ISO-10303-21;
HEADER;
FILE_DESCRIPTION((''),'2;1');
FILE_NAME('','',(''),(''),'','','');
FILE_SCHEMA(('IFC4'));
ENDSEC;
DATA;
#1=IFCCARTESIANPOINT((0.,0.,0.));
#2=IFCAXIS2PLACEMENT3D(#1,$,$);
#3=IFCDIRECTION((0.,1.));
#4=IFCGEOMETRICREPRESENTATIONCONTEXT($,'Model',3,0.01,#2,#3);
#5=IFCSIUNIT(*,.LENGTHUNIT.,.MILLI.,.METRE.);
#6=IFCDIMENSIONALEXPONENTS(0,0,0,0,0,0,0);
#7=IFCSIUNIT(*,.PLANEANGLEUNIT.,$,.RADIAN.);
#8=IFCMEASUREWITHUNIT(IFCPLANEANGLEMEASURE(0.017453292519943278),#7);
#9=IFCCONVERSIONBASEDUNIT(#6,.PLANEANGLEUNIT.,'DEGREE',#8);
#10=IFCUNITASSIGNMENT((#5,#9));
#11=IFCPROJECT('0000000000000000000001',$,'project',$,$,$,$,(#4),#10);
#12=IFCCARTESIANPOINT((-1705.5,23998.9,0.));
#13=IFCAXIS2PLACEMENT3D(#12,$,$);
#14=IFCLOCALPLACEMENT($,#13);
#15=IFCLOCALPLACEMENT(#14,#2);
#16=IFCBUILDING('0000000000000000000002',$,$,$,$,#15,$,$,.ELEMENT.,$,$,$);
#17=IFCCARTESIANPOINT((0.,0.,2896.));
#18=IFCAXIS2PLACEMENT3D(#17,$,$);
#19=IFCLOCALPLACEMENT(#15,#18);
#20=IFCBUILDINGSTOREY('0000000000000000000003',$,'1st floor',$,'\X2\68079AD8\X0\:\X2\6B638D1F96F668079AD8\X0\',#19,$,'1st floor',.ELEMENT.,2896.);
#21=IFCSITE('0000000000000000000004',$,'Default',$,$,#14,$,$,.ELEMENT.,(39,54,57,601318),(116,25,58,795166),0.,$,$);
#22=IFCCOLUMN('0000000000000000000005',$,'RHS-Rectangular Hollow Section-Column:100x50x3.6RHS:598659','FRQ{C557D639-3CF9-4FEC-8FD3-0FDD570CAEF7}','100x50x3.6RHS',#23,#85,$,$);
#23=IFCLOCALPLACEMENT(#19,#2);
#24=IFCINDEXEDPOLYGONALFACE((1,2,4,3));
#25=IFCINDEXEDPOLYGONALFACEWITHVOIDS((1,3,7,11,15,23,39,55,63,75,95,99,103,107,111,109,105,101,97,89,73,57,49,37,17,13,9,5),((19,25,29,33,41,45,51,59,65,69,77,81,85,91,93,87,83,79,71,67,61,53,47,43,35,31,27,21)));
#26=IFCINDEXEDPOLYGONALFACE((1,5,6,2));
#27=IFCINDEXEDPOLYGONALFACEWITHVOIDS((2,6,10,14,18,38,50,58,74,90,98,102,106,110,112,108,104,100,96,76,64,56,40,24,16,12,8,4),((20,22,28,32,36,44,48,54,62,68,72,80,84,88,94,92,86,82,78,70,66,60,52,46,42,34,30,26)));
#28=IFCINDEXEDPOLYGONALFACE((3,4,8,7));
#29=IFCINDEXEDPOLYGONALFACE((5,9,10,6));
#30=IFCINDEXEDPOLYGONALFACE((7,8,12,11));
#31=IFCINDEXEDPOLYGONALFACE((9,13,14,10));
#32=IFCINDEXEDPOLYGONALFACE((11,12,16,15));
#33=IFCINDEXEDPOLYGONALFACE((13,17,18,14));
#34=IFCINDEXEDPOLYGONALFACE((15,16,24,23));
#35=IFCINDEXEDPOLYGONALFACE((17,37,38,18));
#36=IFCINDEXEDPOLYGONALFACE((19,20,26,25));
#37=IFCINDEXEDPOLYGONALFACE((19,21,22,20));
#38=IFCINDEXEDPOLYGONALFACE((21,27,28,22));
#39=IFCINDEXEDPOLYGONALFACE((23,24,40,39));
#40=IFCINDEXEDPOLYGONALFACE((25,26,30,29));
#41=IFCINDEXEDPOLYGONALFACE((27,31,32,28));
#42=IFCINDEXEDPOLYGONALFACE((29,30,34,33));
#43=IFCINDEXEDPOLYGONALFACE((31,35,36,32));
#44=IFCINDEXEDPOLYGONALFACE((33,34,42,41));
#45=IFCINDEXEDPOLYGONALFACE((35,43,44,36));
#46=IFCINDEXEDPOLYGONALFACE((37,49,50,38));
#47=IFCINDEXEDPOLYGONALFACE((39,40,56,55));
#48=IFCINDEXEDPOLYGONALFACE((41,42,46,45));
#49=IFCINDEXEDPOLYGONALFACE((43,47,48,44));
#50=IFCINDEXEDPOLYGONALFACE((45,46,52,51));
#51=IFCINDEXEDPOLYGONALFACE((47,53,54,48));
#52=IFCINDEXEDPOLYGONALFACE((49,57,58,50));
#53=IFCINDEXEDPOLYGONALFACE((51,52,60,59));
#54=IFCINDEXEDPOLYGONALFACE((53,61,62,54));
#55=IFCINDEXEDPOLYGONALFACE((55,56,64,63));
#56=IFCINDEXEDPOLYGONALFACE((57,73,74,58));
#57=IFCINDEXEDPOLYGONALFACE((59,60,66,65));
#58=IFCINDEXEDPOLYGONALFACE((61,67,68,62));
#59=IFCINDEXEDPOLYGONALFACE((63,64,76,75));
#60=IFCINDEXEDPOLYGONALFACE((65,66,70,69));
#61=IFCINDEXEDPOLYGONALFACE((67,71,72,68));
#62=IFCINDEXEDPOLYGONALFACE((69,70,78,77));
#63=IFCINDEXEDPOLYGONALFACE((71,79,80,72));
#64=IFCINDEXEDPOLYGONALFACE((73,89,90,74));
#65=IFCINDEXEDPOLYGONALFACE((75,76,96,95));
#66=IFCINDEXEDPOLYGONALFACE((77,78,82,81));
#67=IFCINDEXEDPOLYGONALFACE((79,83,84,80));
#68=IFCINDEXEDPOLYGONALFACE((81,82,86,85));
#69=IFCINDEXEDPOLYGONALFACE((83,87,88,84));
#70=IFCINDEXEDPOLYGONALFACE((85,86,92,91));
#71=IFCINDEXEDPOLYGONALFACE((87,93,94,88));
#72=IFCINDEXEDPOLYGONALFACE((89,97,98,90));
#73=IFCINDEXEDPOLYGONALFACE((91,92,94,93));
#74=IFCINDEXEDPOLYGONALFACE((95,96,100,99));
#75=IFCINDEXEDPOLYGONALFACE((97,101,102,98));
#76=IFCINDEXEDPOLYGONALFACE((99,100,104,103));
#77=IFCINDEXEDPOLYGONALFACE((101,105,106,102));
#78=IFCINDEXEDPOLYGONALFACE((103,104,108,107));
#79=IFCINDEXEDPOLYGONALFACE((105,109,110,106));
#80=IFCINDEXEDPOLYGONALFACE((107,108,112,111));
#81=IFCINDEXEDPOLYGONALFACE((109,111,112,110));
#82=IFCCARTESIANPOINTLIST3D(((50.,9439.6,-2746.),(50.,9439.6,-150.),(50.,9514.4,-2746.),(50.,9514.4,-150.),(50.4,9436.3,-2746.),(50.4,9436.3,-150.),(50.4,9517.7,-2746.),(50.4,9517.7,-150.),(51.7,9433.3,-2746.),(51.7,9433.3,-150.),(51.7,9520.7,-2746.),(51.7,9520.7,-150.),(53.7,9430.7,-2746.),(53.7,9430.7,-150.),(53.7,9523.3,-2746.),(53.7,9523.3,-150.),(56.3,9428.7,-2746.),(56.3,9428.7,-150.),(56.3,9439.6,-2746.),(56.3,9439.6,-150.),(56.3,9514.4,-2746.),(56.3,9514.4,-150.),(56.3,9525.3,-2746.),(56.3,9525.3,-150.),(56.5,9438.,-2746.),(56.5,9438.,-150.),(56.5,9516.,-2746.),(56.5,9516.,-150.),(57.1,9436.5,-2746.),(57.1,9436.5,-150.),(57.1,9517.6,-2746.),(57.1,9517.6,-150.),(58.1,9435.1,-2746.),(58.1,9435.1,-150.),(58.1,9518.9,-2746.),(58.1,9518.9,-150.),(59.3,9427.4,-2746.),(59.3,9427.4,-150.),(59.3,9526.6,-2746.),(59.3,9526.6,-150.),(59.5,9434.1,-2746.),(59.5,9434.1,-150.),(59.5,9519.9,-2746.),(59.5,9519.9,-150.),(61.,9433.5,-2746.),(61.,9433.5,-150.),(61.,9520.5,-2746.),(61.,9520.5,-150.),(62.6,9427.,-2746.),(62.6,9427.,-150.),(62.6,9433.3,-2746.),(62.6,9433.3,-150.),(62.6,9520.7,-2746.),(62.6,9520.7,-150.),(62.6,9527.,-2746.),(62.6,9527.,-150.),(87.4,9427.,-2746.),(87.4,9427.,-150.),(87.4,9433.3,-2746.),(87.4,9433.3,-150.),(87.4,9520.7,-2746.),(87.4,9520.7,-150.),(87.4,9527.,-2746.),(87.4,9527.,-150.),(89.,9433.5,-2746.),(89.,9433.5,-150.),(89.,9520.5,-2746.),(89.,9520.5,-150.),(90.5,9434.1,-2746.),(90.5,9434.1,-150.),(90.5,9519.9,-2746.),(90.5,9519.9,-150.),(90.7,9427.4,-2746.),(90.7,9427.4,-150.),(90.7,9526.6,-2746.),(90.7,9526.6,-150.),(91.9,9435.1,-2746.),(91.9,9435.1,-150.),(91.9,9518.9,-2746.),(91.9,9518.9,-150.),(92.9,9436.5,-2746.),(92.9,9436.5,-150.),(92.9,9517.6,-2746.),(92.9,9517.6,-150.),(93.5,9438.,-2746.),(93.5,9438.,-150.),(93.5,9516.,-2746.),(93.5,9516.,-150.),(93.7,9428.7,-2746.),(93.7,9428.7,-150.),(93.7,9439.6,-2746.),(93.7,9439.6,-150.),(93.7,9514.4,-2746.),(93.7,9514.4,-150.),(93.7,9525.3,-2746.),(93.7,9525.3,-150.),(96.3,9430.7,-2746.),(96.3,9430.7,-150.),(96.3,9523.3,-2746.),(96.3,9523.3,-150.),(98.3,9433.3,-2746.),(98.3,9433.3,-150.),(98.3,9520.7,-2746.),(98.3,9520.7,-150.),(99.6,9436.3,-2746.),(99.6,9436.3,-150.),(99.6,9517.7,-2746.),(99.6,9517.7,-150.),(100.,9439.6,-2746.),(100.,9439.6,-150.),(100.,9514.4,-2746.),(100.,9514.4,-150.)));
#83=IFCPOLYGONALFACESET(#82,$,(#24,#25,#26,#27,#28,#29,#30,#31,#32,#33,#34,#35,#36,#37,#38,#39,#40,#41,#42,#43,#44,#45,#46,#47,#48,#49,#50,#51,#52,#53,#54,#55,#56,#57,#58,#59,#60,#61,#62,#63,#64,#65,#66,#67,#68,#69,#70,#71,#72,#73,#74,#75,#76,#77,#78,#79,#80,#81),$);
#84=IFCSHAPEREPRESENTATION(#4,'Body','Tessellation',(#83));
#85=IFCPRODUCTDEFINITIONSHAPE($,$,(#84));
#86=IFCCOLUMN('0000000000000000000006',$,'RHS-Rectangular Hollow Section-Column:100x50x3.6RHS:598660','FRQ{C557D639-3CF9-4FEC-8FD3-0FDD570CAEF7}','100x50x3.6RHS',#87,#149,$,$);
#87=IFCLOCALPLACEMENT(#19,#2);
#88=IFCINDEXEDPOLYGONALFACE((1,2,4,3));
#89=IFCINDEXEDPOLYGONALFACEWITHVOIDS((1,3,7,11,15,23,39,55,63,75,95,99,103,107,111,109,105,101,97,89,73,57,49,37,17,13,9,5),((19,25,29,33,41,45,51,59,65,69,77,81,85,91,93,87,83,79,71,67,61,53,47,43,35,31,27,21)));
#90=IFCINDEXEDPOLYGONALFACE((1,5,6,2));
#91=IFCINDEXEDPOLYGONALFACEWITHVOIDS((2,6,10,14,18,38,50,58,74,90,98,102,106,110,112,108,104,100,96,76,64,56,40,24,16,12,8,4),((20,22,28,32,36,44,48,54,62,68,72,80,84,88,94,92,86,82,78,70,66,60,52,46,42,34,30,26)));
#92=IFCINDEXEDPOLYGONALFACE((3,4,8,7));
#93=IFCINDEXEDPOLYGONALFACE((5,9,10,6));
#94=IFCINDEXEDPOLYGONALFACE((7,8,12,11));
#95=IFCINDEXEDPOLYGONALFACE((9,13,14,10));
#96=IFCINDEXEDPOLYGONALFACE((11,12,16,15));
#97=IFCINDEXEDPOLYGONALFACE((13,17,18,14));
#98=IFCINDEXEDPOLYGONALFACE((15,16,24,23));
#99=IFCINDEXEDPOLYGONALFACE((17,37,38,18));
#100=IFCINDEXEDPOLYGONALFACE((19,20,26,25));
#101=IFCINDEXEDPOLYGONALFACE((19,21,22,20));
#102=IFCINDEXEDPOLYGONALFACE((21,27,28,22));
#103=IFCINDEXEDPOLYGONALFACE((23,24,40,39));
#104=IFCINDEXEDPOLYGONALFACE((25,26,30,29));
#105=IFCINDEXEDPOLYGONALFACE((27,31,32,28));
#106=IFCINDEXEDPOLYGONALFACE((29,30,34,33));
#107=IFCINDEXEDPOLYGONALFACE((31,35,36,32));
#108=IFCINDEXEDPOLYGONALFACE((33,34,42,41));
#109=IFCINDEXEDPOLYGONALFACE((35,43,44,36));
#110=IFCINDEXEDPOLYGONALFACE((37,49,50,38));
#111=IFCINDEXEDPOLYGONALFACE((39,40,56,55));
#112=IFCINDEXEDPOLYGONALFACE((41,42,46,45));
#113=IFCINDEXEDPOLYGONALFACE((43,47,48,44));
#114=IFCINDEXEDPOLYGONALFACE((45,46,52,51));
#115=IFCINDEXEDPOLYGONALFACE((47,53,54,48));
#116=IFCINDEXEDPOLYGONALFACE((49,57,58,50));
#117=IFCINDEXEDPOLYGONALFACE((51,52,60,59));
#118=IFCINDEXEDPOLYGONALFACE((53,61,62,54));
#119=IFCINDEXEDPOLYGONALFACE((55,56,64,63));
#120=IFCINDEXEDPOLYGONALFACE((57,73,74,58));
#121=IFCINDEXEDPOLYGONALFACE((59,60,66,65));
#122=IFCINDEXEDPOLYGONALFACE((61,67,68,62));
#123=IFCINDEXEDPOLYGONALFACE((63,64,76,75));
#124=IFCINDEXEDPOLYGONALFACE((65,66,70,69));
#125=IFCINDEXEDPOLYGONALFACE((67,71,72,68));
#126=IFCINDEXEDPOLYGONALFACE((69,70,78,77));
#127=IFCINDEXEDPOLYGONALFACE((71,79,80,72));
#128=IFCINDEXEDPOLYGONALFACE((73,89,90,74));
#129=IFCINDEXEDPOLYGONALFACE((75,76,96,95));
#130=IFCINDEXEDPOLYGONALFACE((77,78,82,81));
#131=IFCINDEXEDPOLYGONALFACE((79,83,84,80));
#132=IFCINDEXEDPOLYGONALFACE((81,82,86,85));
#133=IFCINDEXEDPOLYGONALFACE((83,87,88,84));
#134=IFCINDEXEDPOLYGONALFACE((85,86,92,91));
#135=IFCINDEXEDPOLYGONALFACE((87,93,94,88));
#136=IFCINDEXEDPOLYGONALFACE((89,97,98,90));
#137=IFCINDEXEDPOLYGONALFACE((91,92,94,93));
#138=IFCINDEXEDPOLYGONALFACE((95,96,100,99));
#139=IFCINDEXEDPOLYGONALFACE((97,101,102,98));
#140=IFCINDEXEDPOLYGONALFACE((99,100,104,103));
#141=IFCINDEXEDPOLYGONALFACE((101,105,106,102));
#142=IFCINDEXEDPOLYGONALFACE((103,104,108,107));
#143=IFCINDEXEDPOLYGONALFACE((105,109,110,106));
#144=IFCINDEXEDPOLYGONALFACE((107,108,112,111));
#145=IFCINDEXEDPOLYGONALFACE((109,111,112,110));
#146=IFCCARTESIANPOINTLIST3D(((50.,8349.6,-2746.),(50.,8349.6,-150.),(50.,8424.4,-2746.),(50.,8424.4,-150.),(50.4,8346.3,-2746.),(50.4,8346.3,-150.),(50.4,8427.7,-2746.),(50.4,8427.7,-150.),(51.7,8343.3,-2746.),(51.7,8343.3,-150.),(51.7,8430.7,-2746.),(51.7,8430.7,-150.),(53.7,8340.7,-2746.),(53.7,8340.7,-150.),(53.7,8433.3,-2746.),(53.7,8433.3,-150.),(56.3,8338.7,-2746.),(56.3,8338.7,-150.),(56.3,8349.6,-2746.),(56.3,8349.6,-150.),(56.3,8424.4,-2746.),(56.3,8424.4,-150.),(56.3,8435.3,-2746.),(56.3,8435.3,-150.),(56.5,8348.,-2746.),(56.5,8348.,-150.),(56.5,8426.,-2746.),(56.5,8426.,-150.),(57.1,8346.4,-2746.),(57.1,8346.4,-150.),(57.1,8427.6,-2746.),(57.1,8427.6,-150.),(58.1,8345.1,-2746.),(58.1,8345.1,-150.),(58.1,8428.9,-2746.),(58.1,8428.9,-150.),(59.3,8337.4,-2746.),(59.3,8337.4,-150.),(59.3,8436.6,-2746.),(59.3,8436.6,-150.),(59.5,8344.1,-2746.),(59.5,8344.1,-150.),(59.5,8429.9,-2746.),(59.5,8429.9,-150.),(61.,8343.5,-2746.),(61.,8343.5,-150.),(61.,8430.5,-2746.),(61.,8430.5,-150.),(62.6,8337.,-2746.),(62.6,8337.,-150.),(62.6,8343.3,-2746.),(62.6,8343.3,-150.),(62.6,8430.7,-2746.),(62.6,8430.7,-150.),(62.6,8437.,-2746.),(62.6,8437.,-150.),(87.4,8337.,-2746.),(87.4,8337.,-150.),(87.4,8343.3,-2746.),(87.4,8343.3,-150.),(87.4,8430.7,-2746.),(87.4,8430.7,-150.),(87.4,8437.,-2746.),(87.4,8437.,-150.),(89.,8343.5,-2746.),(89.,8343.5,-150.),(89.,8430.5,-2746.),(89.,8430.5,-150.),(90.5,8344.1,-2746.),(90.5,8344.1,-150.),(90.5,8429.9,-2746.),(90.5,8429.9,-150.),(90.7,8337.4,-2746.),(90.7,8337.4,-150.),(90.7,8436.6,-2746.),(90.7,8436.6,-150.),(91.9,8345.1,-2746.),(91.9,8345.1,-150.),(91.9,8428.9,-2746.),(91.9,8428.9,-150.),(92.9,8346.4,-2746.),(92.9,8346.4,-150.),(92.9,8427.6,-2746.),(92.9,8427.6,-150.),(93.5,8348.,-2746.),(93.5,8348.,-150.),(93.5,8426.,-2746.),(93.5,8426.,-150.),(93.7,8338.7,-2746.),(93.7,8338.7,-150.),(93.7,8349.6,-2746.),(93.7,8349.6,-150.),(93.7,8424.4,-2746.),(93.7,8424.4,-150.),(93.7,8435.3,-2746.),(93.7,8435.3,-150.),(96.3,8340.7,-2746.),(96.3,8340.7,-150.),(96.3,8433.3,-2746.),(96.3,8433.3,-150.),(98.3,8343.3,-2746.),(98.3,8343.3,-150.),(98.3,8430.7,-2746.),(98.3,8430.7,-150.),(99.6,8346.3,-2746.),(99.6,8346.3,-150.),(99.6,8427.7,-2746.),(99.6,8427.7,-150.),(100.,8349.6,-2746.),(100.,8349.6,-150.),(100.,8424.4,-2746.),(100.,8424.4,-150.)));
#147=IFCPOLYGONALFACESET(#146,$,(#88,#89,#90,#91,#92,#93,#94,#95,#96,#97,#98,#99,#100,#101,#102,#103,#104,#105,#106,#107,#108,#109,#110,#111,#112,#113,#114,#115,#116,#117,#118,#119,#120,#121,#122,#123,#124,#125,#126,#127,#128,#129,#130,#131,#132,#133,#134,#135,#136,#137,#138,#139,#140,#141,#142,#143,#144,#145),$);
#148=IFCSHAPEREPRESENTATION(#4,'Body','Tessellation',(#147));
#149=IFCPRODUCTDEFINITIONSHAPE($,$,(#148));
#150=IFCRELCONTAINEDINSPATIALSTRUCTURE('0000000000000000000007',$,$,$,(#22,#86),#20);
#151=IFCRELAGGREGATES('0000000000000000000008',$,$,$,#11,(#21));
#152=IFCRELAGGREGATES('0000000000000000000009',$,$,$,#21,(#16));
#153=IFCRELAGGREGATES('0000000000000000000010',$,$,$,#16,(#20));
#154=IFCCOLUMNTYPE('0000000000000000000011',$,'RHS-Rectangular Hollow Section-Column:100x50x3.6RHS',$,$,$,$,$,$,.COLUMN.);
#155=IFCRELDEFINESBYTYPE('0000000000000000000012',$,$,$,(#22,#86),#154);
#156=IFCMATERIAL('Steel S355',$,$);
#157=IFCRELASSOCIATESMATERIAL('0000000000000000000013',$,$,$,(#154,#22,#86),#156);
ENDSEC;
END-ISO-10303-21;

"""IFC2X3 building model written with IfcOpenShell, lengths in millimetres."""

from ifc_helpers import new_model, entity, si_unit, converted_unit, point, direction, frame, frame_2d, origin, origin_2d, place, context, project, spatial, circle_curve, line_curve, trimmed, segment, composite_curve, hollow_rectangle, outline, extrude, clip, halfspace, material, type_object, element, save


model = new_model("IFC2X3")

# Units and contexts
model_context = context("Model", 3, precision=0.01, world=origin(), true_north=direction((0.0, 1.0)))
ifc_project = project(units=[si_unit("LENGTHUNIT", "METRE", prefix="MILLI"), converted_unit("PLANEANGLEUNIT", "DEGREE", entity("IfcPlaneAngleMeasure", 0.017453292519943278), si_unit("PLANEANGLEUNIT", "RADIAN"), dimensions=[0, 0, 0, 0, 0, 0, 0])], contexts=[model_context])

# Site, building, storey
site_placement = place(None, frame((-1705.5, 23998.9, 0.0)))
site = spatial("IfcSite", under=ifc_project, at=site_placement, Name="Default", CompositionType="ELEMENT", RefLatitude=(39, 54, 57, 601318), RefLongitude=(116, 25, 58, 795166), RefElevation=0.0)
building_placement = place(site_placement, origin())
building = spatial("IfcBuilding", under=site, at=building_placement, CompositionType="ELEMENT")
storey_placement = place(building_placement, frame((0.0, 0.0, 2896.0)))
storey = spatial("IfcBuildingStorey", under=building, at=storey_placement, Name="1st floor", ObjectType="标高:正负零标高", LongName="1st floor", CompositionType="ELEMENT", Elevation=2896.0)

# Columns, openings
ifc_material_1 = material(Name="Steel S355")
column_type_1 = type_object("IfcColumnType", Name="RHS-Rectangular Hollow Section-Column:100x50x3.6RHS", PredefinedType="COLUMN", material=ifc_material_1)
column_1_placement = place(storey_placement, frame((75.0, 9477.0, -19.1)))
column_1 = element("IfcColumn", 1, at=column_1_placement, inside=storey, type_object=column_type_1, material=ifc_material_1, Name="RHS-Rectangular Hollow Section-Column:100x50x3.6RHS:598659", Description="FRQ{C557D639-3CF9-4FEC-8FD3-0FDD570CAEF7}", ObjectType="100x50x3.6RHS", context=model_context, shape_type="Clipping", body=[
    clip(clip(extrude(hollow_rectangle(XDim=50.0, YDim=100.0, WallThickness=6.3, InnerFilletRadius=6.3, OuterFilletRadius=12.6, at=origin_2d()), origin(), (0.0, 0.0, -1.0), 2782.8), halfspace(frame((-75.0, -9477.0, -55.9), z_axis=(0.0, 0.0, -1.0), x_axis=(-1.0, 0.0, 0.0)), True)), halfspace(frame((-75.0, -9477.0, -2726.9), z_axis=(0.0, 0.0, 1.0), x_axis=(1.0, 0.0, 0.0)), True)),
])
opening_1_placement = place(column_1_placement, frame((0.0, -150.1, -130.9), z_axis=(0.0, 1.0, 0.0), x_axis=(-1.0, 0.0, 0.0)))
element("IfcOpeningElement", 2, at=opening_1_placement, cuts=column_1, ObjectType="Opening", context=model_context, shape_type="SweptSolid", body=[
    extrude(outline(composite_curve([segment(trimmed(circle_curve(frame_2d((43.0, 32.0), x_axis=(1.0, 0.0)), 32.0), [point((43.0, 0.0))], [point((75.0, 32.0))], True, "CARTESIAN"), True, "CONTINUOUS"), segment(trimmed(line_curve((75.0, 32.0), (0.0, 1.0), 86.0), [point((75.0, 32.0))], [point((75.0, 118.0))], True, "CARTESIAN"), True, "CONTINUOUS"), segment(trimmed(circle_curve(frame_2d((43.0, 118.0), x_axis=(1.0, 0.0)), 32.0), [point((75.0, 118.0))], [point((43.0, 150.0))], True, "CARTESIAN"), True, "CONTINUOUS"), segment(trimmed(line_curve((43.0, 150.0), (-1.0, 0.0), 86.0), [point((43.0, 150.0))], [point((-43.0, 150.0))], True, "CARTESIAN"), True, "CONTINUOUS"), segment(trimmed(circle_curve(frame_2d((-43.0, 118.0), x_axis=(1.0, 0.0)), 32.0), [point((-43.0, 150.0))], [point((-75.0, 118.0))], True, "CARTESIAN"), True, "CONTINUOUS"), segment(trimmed(line_curve((-75.0, 118.0), (0.0, -1.0), 86.0), [point((-75.0, 118.0))], [point((-75.0, 32.0))], True, "CARTESIAN"), True, "CONTINUOUS"), segment(trimmed(circle_curve(frame_2d((-43.0, 32.0), x_axis=(1.0, 0.0)), 32.0), [point((-75.0, 32.0))], [point((-43.0, 0.0))], True, "CARTESIAN"), True, "CONTINUOUS"), segment(trimmed(line_curve((-43.0, 0.0), (1.0, 0.0), 86.0), [point((-43.0, 0.0))], [point((43.0, 0.0))], True, "CARTESIAN"), True, "CONTINUOUS")], self_intersect="UNKNOWN")), origin(), (0.0, 0.0, 1.0), 300.2),
])
column_2_placement = place(storey_placement, frame((75.0, 8387.0, -19.1)))
column_2 = element("IfcColumn", 3, at=column_2_placement, inside=storey, type_object=column_type_1, material=ifc_material_1, Name="RHS-Rectangular Hollow Section-Column:100x50x3.6RHS:598660", Description="FRQ{C557D639-3CF9-4FEC-8FD3-0FDD570CAEF7}", ObjectType="100x50x3.6RHS", context=model_context, shape_type="Clipping", body=[
    clip(clip(extrude(hollow_rectangle(XDim=50.0, YDim=100.0, WallThickness=6.3, InnerFilletRadius=6.3, OuterFilletRadius=12.6, at=origin_2d()), origin(), (0.0, 0.0, -1.0), 2782.8), halfspace(frame((-75.0, -8387.0, -2726.9), z_axis=(0.0, 0.0, 1.0), x_axis=(1.0, 0.0, 0.0)), True)), halfspace(frame((-75.0, -8387.0, -55.9), z_axis=(0.0, 0.0, -1.0), x_axis=(-1.0, 0.0, 0.0)), True)),
])
opening_2_placement = place(column_2_placement, frame((0.0, -150.1, -130.9), z_axis=(0.0, 1.0, 0.0), x_axis=(-1.0, 0.0, 0.0)))
element("IfcOpeningElement", 4, at=opening_2_placement, cuts=column_2, ObjectType="Opening", context=model_context, shape_type="SweptSolid", body=[
    extrude(outline(composite_curve([segment(trimmed(circle_curve(frame_2d((43.0, 32.0), x_axis=(1.0, 0.0)), 32.0), [point((43.0, 0.0))], [point((75.0, 32.0))], True, "CARTESIAN"), True, "CONTINUOUS"), segment(trimmed(line_curve((75.0, 32.0), (0.0, 1.0), 86.0), [point((75.0, 32.0))], [point((75.0, 118.0))], True, "CARTESIAN"), True, "CONTINUOUS"), segment(trimmed(circle_curve(frame_2d((43.0, 118.0), x_axis=(1.0, 0.0)), 32.0), [point((75.0, 118.0))], [point((43.0, 150.0))], True, "CARTESIAN"), True, "CONTINUOUS"), segment(trimmed(line_curve((43.0, 150.0), (-1.0, 0.0), 86.0), [point((43.0, 150.0))], [point((-43.0, 150.0))], True, "CARTESIAN"), True, "CONTINUOUS"), segment(trimmed(circle_curve(frame_2d((-43.0, 118.0), x_axis=(1.0, 0.0)), 32.0), [point((-43.0, 150.0))], [point((-75.0, 118.0))], True, "CARTESIAN"), True, "CONTINUOUS"), segment(trimmed(line_curve((-75.0, 118.0), (0.0, -1.0), 86.0), [point((-75.0, 118.0))], [point((-75.0, 32.0))], True, "CARTESIAN"), True, "CONTINUOUS"), segment(trimmed(circle_curve(frame_2d((-43.0, 32.0), x_axis=(1.0, 0.0)), 32.0), [point((-75.0, 32.0))], [point((-43.0, 0.0))], True, "CARTESIAN"), True, "CONTINUOUS"), segment(trimmed(line_curve((-43.0, 0.0), (1.0, 0.0), 86.0), [point((-43.0, 0.0))], [point((43.0, 0.0))], True, "CARTESIAN"), True, "CONTINUOUS")], self_intersect="UNKNOWN")), origin(), (0.0, 0.0, 1.0), 300.2),
])

save(model, "model.ifc")
